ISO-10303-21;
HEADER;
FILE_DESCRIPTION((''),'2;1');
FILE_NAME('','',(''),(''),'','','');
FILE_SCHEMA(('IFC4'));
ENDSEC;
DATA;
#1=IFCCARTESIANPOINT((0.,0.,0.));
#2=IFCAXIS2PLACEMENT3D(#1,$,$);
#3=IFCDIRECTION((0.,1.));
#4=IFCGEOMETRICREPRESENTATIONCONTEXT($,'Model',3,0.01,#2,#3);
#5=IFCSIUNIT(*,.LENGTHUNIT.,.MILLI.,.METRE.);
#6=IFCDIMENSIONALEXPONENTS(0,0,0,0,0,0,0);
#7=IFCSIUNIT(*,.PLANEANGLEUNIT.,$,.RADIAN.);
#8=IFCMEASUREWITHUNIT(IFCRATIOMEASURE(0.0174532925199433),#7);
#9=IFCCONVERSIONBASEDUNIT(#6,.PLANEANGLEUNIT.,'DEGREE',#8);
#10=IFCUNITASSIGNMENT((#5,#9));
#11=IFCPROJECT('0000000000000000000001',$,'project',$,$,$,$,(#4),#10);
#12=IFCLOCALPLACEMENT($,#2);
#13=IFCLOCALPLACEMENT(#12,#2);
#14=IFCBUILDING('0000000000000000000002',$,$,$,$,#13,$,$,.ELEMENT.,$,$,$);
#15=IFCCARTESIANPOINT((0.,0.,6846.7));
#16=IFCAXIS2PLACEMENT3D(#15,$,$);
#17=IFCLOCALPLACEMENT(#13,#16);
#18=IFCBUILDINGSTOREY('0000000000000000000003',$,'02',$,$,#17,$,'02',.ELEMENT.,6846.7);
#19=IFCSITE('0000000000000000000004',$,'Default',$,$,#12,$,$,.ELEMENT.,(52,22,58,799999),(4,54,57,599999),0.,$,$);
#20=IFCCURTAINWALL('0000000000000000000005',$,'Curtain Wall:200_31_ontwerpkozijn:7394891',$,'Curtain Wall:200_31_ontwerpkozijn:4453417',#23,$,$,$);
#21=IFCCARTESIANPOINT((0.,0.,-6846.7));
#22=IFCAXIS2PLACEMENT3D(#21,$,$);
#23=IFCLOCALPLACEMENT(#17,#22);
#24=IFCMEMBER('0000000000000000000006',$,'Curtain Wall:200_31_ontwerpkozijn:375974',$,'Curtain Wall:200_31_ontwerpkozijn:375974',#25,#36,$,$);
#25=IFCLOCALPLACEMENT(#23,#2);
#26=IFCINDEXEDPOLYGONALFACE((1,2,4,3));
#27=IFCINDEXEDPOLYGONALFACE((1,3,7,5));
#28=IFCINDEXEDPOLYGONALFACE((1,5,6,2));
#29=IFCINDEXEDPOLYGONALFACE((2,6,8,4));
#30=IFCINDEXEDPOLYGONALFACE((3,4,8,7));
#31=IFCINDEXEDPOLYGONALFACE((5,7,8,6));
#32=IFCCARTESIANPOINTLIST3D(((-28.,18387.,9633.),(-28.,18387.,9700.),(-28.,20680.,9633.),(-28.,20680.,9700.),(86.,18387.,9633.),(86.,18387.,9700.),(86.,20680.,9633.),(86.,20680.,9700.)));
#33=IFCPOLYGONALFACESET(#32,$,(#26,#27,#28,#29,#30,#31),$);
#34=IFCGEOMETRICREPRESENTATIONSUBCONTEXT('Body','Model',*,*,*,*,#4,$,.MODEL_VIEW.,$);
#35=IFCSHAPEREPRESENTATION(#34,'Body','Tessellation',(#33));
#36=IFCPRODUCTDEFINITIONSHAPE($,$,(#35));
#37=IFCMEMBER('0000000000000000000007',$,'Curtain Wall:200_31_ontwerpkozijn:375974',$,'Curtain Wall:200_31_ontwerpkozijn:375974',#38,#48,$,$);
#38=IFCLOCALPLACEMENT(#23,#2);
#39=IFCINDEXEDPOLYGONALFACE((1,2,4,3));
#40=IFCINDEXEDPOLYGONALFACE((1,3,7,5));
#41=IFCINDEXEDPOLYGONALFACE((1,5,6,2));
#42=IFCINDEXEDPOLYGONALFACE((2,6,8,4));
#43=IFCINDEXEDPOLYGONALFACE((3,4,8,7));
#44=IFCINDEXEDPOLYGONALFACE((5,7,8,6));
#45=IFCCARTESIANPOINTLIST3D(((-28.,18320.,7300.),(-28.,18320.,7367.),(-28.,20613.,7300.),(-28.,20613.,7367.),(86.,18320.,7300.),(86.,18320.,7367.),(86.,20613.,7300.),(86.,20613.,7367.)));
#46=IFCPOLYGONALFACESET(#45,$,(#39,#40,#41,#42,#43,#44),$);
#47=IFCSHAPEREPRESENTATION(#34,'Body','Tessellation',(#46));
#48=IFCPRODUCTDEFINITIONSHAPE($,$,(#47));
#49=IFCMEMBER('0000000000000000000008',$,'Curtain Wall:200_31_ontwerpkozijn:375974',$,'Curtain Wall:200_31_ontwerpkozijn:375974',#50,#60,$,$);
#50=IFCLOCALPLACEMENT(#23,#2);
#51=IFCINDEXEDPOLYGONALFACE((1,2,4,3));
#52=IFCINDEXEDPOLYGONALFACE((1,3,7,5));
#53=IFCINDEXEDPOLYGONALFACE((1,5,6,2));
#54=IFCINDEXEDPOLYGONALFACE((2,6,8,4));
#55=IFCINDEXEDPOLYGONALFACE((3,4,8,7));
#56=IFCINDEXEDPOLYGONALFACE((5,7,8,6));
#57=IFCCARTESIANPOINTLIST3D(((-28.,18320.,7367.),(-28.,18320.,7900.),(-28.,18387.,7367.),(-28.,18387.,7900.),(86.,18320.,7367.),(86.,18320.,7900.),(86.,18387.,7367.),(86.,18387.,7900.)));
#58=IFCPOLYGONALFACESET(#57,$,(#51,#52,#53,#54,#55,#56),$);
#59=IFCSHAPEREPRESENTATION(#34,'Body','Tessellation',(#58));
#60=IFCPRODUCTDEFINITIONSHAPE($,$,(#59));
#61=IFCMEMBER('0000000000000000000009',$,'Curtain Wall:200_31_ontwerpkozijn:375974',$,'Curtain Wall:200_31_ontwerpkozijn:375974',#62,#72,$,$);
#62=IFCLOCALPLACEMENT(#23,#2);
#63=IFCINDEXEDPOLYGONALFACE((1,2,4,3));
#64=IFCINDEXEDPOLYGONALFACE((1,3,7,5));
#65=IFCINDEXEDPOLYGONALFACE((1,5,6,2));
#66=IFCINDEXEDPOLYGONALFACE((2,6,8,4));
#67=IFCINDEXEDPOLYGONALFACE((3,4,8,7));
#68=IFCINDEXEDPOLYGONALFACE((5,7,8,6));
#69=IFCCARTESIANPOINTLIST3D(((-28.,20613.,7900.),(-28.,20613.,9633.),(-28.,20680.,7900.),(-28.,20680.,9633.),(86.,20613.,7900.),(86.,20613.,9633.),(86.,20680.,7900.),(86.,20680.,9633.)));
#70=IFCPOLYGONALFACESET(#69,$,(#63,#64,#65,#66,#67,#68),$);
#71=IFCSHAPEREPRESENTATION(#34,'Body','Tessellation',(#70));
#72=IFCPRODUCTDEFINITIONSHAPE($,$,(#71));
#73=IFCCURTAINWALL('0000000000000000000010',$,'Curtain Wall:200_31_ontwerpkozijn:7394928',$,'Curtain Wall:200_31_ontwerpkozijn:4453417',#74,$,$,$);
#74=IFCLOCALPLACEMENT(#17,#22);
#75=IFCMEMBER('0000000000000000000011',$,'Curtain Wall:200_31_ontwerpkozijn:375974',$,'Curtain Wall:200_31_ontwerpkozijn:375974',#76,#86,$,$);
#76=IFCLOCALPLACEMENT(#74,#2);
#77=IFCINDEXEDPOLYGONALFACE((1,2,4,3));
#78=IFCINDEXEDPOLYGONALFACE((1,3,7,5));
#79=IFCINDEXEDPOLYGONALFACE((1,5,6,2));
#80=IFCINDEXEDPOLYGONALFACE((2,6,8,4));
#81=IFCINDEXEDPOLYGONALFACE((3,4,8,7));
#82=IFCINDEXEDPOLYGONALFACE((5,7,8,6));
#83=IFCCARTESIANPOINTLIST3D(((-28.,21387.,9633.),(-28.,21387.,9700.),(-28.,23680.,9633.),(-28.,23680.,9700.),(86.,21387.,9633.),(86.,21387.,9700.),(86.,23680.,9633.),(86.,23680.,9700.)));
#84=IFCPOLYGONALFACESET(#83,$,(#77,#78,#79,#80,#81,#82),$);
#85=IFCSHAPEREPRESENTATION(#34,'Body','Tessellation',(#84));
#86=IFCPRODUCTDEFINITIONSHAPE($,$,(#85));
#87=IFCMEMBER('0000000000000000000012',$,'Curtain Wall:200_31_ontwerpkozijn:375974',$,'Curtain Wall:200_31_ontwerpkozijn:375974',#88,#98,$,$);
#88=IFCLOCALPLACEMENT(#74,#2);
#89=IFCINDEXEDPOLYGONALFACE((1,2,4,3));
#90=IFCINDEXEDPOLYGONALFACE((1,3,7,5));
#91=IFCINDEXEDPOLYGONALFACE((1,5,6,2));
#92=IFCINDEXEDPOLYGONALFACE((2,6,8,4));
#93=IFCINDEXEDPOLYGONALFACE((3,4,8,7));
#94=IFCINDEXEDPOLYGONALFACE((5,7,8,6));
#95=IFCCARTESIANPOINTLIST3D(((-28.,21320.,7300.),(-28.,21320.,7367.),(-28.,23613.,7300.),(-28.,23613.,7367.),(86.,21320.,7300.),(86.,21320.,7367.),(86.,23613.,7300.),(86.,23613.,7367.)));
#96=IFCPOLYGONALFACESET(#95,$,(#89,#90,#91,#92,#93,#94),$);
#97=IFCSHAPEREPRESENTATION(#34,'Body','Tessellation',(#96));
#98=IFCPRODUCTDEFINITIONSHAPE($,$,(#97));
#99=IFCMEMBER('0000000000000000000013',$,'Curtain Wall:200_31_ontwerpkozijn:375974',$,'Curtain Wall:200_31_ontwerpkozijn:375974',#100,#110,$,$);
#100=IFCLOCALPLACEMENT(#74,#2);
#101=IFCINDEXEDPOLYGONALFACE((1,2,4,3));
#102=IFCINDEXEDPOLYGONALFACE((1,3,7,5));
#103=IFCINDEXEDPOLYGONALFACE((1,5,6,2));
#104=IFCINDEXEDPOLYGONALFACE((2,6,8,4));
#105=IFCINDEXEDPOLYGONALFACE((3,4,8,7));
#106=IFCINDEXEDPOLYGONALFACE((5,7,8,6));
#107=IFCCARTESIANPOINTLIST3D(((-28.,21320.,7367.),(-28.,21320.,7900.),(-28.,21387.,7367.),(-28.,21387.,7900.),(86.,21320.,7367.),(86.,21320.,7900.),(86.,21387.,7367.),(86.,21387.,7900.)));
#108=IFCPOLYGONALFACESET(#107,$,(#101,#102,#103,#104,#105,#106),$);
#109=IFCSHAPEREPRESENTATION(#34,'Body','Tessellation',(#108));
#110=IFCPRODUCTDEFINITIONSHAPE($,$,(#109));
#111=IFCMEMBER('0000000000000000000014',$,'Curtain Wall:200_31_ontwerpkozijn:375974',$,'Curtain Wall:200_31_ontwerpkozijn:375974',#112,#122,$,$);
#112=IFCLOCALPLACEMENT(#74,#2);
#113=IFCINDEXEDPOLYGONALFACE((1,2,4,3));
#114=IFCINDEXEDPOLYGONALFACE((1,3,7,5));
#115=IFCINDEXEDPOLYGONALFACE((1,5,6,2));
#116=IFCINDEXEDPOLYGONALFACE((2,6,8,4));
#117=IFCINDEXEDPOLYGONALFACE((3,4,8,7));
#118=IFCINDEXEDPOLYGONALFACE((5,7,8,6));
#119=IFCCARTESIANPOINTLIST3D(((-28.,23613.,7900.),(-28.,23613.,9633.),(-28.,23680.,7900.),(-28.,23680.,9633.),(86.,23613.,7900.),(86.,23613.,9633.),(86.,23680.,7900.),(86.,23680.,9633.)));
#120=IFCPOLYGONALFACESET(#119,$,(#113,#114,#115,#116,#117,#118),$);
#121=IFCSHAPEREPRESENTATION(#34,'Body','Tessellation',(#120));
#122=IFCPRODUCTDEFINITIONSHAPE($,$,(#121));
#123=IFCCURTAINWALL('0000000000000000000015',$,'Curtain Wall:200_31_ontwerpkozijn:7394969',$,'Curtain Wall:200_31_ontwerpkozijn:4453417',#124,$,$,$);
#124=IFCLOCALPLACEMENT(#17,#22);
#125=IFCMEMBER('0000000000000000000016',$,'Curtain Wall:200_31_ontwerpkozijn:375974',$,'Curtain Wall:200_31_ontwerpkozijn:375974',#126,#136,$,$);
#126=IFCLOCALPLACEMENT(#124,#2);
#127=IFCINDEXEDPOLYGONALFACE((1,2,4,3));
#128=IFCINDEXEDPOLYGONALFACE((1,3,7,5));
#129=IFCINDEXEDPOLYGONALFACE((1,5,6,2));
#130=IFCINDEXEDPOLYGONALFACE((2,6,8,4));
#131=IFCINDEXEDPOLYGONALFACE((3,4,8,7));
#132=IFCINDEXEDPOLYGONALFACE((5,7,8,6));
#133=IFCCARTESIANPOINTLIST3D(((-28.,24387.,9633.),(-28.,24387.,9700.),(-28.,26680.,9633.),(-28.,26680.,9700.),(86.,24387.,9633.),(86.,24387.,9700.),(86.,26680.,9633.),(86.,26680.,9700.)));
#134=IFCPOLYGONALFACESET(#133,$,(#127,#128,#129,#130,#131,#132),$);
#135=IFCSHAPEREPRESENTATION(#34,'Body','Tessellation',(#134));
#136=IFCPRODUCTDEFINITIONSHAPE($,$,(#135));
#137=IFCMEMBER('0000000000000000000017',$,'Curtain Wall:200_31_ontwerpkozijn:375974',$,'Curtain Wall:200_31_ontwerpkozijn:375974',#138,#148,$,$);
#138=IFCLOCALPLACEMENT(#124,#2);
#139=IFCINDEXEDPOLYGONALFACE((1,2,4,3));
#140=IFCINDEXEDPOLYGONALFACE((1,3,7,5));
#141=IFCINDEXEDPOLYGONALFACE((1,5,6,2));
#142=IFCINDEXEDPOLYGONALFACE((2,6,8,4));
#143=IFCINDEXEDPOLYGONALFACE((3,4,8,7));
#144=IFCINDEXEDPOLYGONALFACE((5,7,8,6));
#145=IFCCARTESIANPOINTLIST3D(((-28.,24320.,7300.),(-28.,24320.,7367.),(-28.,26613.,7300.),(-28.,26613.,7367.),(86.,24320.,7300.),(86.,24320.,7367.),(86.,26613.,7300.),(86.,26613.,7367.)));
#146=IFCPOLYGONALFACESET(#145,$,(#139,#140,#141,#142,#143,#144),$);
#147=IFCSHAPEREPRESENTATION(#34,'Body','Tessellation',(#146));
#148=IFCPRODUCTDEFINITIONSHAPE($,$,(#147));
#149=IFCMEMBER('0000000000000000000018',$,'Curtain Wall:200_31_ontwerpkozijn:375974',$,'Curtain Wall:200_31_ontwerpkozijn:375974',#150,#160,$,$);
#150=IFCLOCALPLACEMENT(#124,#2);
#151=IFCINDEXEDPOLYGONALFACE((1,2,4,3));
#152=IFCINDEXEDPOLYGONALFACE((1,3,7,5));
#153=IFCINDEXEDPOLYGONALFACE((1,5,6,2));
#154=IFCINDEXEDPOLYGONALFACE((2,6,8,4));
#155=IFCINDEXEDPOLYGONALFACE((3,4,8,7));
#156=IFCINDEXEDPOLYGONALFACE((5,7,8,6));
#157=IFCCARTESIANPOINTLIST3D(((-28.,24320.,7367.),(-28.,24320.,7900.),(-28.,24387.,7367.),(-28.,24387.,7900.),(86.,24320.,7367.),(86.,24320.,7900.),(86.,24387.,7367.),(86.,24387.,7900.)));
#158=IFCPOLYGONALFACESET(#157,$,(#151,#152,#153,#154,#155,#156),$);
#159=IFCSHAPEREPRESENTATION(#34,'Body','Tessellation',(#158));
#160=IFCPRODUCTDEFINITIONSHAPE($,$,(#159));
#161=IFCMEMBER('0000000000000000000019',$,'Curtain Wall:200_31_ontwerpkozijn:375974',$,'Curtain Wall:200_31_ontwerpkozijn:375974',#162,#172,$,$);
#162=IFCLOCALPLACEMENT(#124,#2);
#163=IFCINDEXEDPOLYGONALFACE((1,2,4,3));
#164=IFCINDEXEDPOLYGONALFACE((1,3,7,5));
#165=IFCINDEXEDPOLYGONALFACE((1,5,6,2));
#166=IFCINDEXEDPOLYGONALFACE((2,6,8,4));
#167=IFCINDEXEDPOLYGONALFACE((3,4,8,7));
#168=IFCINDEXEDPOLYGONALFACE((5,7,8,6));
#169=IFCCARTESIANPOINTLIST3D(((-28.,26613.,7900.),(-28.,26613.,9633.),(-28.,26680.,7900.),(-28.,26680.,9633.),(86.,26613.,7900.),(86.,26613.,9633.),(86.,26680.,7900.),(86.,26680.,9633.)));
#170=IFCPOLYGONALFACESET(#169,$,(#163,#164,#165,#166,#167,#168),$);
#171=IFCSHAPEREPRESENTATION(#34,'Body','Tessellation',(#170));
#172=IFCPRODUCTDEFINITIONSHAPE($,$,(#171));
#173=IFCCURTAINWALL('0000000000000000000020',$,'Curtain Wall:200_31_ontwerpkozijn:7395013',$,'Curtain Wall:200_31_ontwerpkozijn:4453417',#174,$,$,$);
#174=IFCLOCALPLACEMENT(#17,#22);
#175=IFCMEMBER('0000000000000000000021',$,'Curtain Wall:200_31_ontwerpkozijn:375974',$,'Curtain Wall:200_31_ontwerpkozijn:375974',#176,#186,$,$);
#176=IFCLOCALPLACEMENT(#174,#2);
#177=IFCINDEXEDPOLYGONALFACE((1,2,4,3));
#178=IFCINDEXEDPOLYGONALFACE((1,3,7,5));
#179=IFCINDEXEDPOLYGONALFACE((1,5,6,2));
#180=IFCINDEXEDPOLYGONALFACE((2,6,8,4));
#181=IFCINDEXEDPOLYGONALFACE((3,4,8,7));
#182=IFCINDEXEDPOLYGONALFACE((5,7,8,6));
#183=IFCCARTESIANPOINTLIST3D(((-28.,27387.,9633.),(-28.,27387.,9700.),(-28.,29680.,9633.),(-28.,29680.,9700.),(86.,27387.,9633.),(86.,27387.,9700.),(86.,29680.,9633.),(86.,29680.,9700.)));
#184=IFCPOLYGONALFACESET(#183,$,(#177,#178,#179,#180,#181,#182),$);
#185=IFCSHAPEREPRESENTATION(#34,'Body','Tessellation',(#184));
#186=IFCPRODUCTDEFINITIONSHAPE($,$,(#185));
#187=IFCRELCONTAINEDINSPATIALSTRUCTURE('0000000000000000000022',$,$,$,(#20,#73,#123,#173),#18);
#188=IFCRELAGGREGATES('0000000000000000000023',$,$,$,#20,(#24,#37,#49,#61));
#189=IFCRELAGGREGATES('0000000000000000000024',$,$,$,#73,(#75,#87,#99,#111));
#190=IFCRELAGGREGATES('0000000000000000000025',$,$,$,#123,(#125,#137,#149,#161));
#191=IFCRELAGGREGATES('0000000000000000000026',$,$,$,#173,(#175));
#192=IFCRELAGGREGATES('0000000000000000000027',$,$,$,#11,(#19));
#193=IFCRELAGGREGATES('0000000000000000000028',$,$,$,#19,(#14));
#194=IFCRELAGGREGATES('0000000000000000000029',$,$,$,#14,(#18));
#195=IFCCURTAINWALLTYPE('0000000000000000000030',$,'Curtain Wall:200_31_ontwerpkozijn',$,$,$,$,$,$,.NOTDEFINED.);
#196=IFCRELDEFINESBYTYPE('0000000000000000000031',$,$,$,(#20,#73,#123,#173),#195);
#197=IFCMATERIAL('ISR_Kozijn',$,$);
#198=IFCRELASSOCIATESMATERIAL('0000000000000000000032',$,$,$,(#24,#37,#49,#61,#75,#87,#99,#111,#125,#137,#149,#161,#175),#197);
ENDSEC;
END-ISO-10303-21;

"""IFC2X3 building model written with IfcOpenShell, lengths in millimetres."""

from ifc_helpers import new_model, entity, si_unit, converted_unit, direction, frame, frame_2d, origin, origin_2d_with_axis, place, context, subcontext, project, spatial, rectangle, extrude, material, type_object, element, aggregate, save


model = new_model("IFC2X3")

# Units and contexts
model_context = context("Model", 3, precision=0.01, world=origin(), true_north=direction((0.0, 1.0)))
body_context = subcontext(model_context, "Body", "Model", "MODEL_VIEW")
ifc_project = project(units=[si_unit("LENGTHUNIT", "METRE", prefix="MILLI"), converted_unit("PLANEANGLEUNIT", "DEGREE", entity("IfcRatioMeasure", 0.0174532925199433), si_unit("PLANEANGLEUNIT", "RADIAN"), dimensions=[0, 0, 0, 0, 0, 0, 0])], contexts=[model_context])

# Site, building, storey
site_placement = place(None, origin())
site = spatial("IfcSite", under=ifc_project, at=site_placement, Name="Default", CompositionType="ELEMENT", RefLatitude=(52, 22, 58, 799999), RefLongitude=(4, 54, 57, 599999), RefElevation=0.0)
building_placement = place(site_placement, origin())
building = spatial("IfcBuilding", under=site, at=building_placement, CompositionType="ELEMENT")
storey_placement = place(building_placement, frame((0.0, 0.0, 6846.7)))
storey = spatial("IfcBuildingStorey", under=building, at=storey_placement, Name="02", LongName="02", CompositionType="ELEMENT", Elevation=6846.7)

# Shared definitions
curtain_wall_type = type_object("IfcCurtainWallType", Name="Curtain Wall:200_31_ontwerpkozijn", PredefinedType="NOTDEFINED")
ifc_material = material(Name="ISR_Kozijn")

# Curtain walls, members
curtain_wall_1_placement = place(storey_placement, frame((0.0, 0.0, -6846.7)))
curtain_wall_1 = element("IfcCurtainWall", 1, at=curtain_wall_1_placement, inside=storey, type_object=curtain_wall_type, Name="Curtain Wall:200_31_ontwerpkozijn:7394891", ObjectType="Curtain Wall:200_31_ontwerpkozijn:4453417")
member_1_placement = place(curtain_wall_1_placement, origin())
member_1 = element("IfcMember", 2, at=member_1_placement, material=ifc_material, Name="Curtain Wall:200_31_ontwerpkozijn:375974", ObjectType="Curtain Wall:200_31_ontwerpkozijn:375974", context=body_context, shape_type="SweptSolid", body=[
    extrude(rectangle(XDim=67.0, YDim=114.0, at=origin_2d_with_axis()), frame((29.0, 18387.0, 9666.5), z_axis=(0.0, 1.0, 0.0), x_axis=(0.0, 0.0, -1.0)), (0.0, 0.0, 1.0), 2293.0),
])
member_2_placement = place(curtain_wall_1_placement, origin())
member_2 = element("IfcMember", 3, at=member_2_placement, material=ifc_material, Name="Curtain Wall:200_31_ontwerpkozijn:375974", ObjectType="Curtain Wall:200_31_ontwerpkozijn:375974", context=body_context, shape_type="SweptSolid", body=[
    extrude(rectangle(XDim=67.0, YDim=114.0, at=frame_2d((0.0, 0.0), x_axis=(1.0, 0.0))), frame((29.0, 20613.0, 7333.5), z_axis=(0.0, -1.0, 0.0), x_axis=(0.0, 0.0, -1.0)), (0.0, 0.0, 1.0), 2293.0),
])
member_3_placement = place(curtain_wall_1_placement, origin())
member_3 = element("IfcMember", 4, at=member_3_placement, material=ifc_material, Name="Curtain Wall:200_31_ontwerpkozijn:375974", ObjectType="Curtain Wall:200_31_ontwerpkozijn:375974", context=body_context, shape_type="SweptSolid", body=[
    extrude(rectangle(XDim=114.0, YDim=67.0, at=frame_2d((0.0, 0.0), x_axis=(1.0, 0.0))), frame((29.0, 18353.5, 7367.0), z_axis=(0.0, 0.0, 1.0), x_axis=(-1.0, 0.0, 0.0)), (0.0, 0.0, 1.0), 533.0),
])
member_4_placement = place(curtain_wall_1_placement, origin())
member_4 = element("IfcMember", 5, at=member_4_placement, material=ifc_material, Name="Curtain Wall:200_31_ontwerpkozijn:375974", ObjectType="Curtain Wall:200_31_ontwerpkozijn:375974", context=body_context, shape_type="SweptSolid", body=[
    extrude(rectangle(XDim=114.0, YDim=67.0, at=origin_2d_with_axis()), frame((29.0, 20646.5, 9633.0), z_axis=(0.0, 0.0, -1.0), x_axis=(-1.0, 0.0, 0.0)), (0.0, 0.0, 1.0), 1733.0),
])
aggregate(curtain_wall_1, [member_1, member_2, member_3, member_4])
curtain_wall_2_placement = place(storey_placement, frame((0.0, 0.0, -6846.7)))
curtain_wall_2 = element("IfcCurtainWall", 6, at=curtain_wall_2_placement, inside=storey, type_object=curtain_wall_type, Name="Curtain Wall:200_31_ontwerpkozijn:7394928", ObjectType="Curtain Wall:200_31_ontwerpkozijn:4453417")
member_5_placement = place(curtain_wall_2_placement, origin())
member_5 = element("IfcMember", 7, at=member_5_placement, material=ifc_material, Name="Curtain Wall:200_31_ontwerpkozijn:375974", ObjectType="Curtain Wall:200_31_ontwerpkozijn:375974", context=body_context, shape_type="SweptSolid", body=[
    extrude(rectangle(XDim=67.0, YDim=114.0, at=origin_2d_with_axis()), frame((29.0, 21387.0, 9666.5), z_axis=(0.0, 1.0, 0.0), x_axis=(0.0, 0.0, -1.0)), (0.0, 0.0, 1.0), 2293.0),
])
member_6_placement = place(curtain_wall_2_placement, origin())
member_6 = element("IfcMember", 8, at=member_6_placement, material=ifc_material, Name="Curtain Wall:200_31_ontwerpkozijn:375974", ObjectType="Curtain Wall:200_31_ontwerpkozijn:375974", context=body_context, shape_type="SweptSolid", body=[
    extrude(rectangle(XDim=67.0, YDim=114.0, at=frame_2d((0.0, 0.0), x_axis=(1.0, 0.0))), frame((29.0, 23613.0, 7333.5), z_axis=(0.0, -1.0, 0.0), x_axis=(0.0, 0.0, -1.0)), (0.0, 0.0, 1.0), 2293.0),
])
member_7_placement = place(curtain_wall_2_placement, origin())
member_7 = element("IfcMember", 9, at=member_7_placement, material=ifc_material, Name="Curtain Wall:200_31_ontwerpkozijn:375974", ObjectType="Curtain Wall:200_31_ontwerpkozijn:375974", context=body_context, shape_type="SweptSolid", body=[
    extrude(rectangle(XDim=114.0, YDim=67.0, at=origin_2d_with_axis()), frame((29.0, 21353.5, 7367.0), z_axis=(0.0, 0.0, 1.0), x_axis=(-1.0, 0.0, 0.0)), (0.0, 0.0, 1.0), 533.0),
])
member_8_placement = place(curtain_wall_2_placement, origin())
member_8 = element("IfcMember", 10, at=member_8_placement, material=ifc_material, Name="Curtain Wall:200_31_ontwerpkozijn:375974", ObjectType="Curtain Wall:200_31_ontwerpkozijn:375974", context=body_context, shape_type="SweptSolid", body=[
    extrude(rectangle(XDim=114.0, YDim=67.0, at=origin_2d_with_axis()), frame((29.0, 23646.5, 9633.0), z_axis=(0.0, 0.0, -1.0), x_axis=(-1.0, 0.0, 0.0)), (0.0, 0.0, 1.0), 1733.0),
])
aggregate(curtain_wall_2, [member_5, member_6, member_7, member_8])
curtain_wall_3_placement = place(storey_placement, frame((0.0, 0.0, -6846.7)))
curtain_wall_3 = element("IfcCurtainWall", 11, at=curtain_wall_3_placement, inside=storey, type_object=curtain_wall_type, Name="Curtain Wall:200_31_ontwerpkozijn:7394969", ObjectType="Curtain Wall:200_31_ontwerpkozijn:4453417")
member_9_placement = place(curtain_wall_3_placement, origin())
member_9 = element("IfcMember", 12, at=member_9_placement, material=ifc_material, Name="Curtain Wall:200_31_ontwerpkozijn:375974", ObjectType="Curtain Wall:200_31_ontwerpkozijn:375974", context=body_context, shape_type="SweptSolid", body=[
    extrude(rectangle(XDim=67.0, YDim=114.0, at=origin_2d_with_axis()), frame((29.0, 24387.0, 9666.5), z_axis=(0.0, 1.0, 0.0), x_axis=(0.0, 0.0, -1.0)), (0.0, 0.0, 1.0), 2293.0),
])
member_10_placement = place(curtain_wall_3_placement, origin())
member_10 = element("IfcMember", 13, at=member_10_placement, material=ifc_material, Name="Curtain Wall:200_31_ontwerpkozijn:375974", ObjectType="Curtain Wall:200_31_ontwerpkozijn:375974", context=body_context, shape_type="SweptSolid", body=[
    extrude(rectangle(XDim=67.0, YDim=114.0, at=frame_2d((0.0, 0.0), x_axis=(1.0, 0.0))), frame((29.0, 26613.0, 7333.5), z_axis=(0.0, -1.0, 0.0), x_axis=(0.0, 0.0, -1.0)), (0.0, 0.0, 1.0), 2293.0),
])
member_11_placement = place(curtain_wall_3_placement, origin())
member_11 = element("IfcMember", 14, at=member_11_placement, material=ifc_material, Name="Curtain Wall:200_31_ontwerpkozijn:375974", ObjectType="Curtain Wall:200_31_ontwerpkozijn:375974", context=body_context, shape_type="SweptSolid", body=[
    extrude(rectangle(XDim=114.0, YDim=67.0, at=origin_2d_with_axis()), frame((29.0, 24353.5, 7367.0), z_axis=(0.0, 0.0, 1.0), x_axis=(-1.0, 0.0, 0.0)), (0.0, 0.0, 1.0), 533.0),
])
member_12_placement = place(curtain_wall_3_placement, origin())
member_12 = element("IfcMember", 15, at=member_12_placement, material=ifc_material, Name="Curtain Wall:200_31_ontwerpkozijn:375974", ObjectType="Curtain Wall:200_31_ontwerpkozijn:375974", context=body_context, shape_type="SweptSolid", body=[
    extrude(rectangle(XDim=114.0, YDim=67.0, at=origin_2d_with_axis()), frame((29.0, 26646.5, 9633.0), z_axis=(0.0, 0.0, -1.0), x_axis=(-1.0, 0.0, 0.0)), (0.0, 0.0, 1.0), 1733.0),
])
aggregate(curtain_wall_3, [member_9, member_10, member_11, member_12])
curtain_wall_4_placement = place(storey_placement, frame((0.0, 0.0, -6846.7)))
curtain_wall_4 = element("IfcCurtainWall", 16, at=curtain_wall_4_placement, inside=storey, type_object=curtain_wall_type, Name="Curtain Wall:200_31_ontwerpkozijn:7395013", ObjectType="Curtain Wall:200_31_ontwerpkozijn:4453417")
member_13_placement = place(curtain_wall_4_placement, origin())
member_13 = element("IfcMember", 17, at=member_13_placement, material=ifc_material, Name="Curtain Wall:200_31_ontwerpkozijn:375974", ObjectType="Curtain Wall:200_31_ontwerpkozijn:375974", context=body_context, shape_type="SweptSolid", body=[
    extrude(rectangle(XDim=67.0, YDim=114.0, at=origin_2d_with_axis()), frame((29.0, 27387.0, 9666.5), z_axis=(0.0, 1.0, 0.0), x_axis=(0.0, 0.0, -1.0)), (0.0, 0.0, 1.0), 2293.0),
])
aggregate(curtain_wall_4, [member_13])

save(model, "model.ifc")
